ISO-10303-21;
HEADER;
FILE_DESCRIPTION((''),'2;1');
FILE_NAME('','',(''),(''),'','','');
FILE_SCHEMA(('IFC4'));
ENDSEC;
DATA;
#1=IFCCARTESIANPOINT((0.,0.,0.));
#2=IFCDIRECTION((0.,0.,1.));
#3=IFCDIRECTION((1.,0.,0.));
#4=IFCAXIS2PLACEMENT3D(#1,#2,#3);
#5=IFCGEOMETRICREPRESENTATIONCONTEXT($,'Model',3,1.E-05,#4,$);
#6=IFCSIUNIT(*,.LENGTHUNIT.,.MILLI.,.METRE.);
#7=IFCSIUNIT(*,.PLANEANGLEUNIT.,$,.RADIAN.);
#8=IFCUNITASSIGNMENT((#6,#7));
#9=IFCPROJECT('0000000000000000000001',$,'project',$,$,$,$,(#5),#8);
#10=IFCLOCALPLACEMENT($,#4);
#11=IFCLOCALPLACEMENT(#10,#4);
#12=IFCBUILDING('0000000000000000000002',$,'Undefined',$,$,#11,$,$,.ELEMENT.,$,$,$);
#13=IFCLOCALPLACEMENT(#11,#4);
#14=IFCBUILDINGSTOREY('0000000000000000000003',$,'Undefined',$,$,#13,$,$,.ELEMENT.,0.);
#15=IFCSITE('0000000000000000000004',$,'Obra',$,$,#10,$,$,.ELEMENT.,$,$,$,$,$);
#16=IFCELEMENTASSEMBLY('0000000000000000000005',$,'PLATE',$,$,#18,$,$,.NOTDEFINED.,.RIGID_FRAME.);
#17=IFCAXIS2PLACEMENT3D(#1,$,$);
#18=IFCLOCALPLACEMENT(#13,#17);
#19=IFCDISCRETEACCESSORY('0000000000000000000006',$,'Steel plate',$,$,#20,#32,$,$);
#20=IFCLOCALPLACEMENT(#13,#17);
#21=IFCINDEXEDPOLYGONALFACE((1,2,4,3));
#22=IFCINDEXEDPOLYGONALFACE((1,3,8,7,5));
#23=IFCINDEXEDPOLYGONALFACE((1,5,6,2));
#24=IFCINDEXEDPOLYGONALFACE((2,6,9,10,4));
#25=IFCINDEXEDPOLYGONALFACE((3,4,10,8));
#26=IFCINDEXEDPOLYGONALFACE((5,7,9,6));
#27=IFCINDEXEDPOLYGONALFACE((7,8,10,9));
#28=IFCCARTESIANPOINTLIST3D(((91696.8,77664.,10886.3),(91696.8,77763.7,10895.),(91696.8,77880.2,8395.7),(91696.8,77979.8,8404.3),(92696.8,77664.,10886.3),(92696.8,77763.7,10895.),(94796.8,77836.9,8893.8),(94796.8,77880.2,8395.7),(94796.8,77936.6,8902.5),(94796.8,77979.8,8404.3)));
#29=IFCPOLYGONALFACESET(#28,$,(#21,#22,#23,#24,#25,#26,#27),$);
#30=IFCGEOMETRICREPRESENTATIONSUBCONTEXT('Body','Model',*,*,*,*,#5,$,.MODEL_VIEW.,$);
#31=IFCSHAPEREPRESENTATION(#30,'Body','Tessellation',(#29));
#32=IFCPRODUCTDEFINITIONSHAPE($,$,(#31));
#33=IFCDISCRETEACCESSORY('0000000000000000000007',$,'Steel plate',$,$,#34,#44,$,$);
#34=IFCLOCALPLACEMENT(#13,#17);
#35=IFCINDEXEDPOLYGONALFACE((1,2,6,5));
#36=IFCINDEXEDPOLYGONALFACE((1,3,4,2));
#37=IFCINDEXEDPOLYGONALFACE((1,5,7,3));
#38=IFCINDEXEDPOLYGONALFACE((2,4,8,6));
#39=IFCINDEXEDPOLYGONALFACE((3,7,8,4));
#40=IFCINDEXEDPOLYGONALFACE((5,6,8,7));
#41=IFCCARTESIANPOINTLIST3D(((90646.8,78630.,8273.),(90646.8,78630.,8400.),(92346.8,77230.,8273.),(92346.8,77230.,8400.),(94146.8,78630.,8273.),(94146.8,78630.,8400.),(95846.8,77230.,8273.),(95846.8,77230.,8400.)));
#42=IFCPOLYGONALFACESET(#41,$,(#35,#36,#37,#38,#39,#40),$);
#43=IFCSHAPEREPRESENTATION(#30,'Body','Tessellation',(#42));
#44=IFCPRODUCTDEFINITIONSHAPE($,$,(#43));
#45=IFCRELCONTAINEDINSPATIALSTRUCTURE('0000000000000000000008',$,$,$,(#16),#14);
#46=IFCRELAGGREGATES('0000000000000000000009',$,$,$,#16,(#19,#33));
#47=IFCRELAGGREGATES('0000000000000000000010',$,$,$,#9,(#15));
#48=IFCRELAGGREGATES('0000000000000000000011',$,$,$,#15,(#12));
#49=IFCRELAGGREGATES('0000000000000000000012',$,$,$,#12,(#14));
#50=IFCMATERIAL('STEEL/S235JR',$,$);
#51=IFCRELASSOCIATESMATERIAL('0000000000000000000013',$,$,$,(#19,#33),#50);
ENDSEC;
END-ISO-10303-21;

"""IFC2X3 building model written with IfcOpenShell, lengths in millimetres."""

from ifc_helpers import new_model, si_unit, frame, origin_with_axes, place, context, subcontext, project, spatial, polyline, outline, extrude, material, element, aggregate, save


model = new_model("IFC2X3")

# Units and contexts
model_context = context("Model", 3, precision=1e-05, world=origin_with_axes())
body_context = subcontext(model_context, "Body", "Model", "MODEL_VIEW")
ifc_project = project(units=[si_unit("LENGTHUNIT", "METRE", prefix="MILLI"), si_unit("PLANEANGLEUNIT", "RADIAN")], contexts=[model_context])

# Site, building, storey
site_placement = place(None, origin_with_axes())
site = spatial("IfcSite", under=ifc_project, at=site_placement, Name="Obra", CompositionType="ELEMENT")
building_placement = place(site_placement, origin_with_axes())
building = spatial("IfcBuilding", under=site, at=building_placement, Name="Undefined", CompositionType="ELEMENT")
storey_placement = place(building_placement, origin_with_axes())
storey = spatial("IfcBuildingStorey", under=building, at=storey_placement, Name="Undefined", CompositionType="ELEMENT", Elevation=0.0)

# Shared definitions
ifc_material_1 = material(Name="STEEL/S235JR")

# Element assembly
assembly_1_placement = place(storey_placement, origin_with_axes())
assembly_1 = element("IfcElementAssembly", 1, at=assembly_1_placement, inside=storey, Name="PLATE", AssemblyPlace="NOTDEFINED", PredefinedType="RIGID_FRAME")

# Discrete accessories
discrete_accessory_1_placement = place(assembly_1_placement, frame((94796.8, 77886.8, 8898.1), z_axis=(0.0, 0.996255, 0.08646), x_axis=(0.0, 0.08646, -0.996255)))
discrete_accessory_1 = element("IfcDiscreteAccessory", 2, at=discrete_accessory_1_placement, material=ifc_material_1, Name="Steel plate", context=body_context, shape_type="SweptSolid", body=[
    extrude(outline(polyline([(0.0, 0.0), (500.0, 0.0), (500.0, 3100.0), (-2000.0, 3100.0), (-2000.0, 2100.0), (0.0, 0.0)])), frame((0.0, 0.0, -50.0), z_axis=(0.0, 0.0, 1.0), x_axis=(1.0, 0.0, 0.0)), (0.0, 0.0, 1.0), 100.0),
])
discrete_accessory_2_placement = place(assembly_1_placement, frame((92346.8, 77230.0, 8336.5), z_axis=(0.0, 0.0, 1.0), x_axis=(1.0, 0.0, 0.0)))
discrete_accessory_2 = element("IfcDiscreteAccessory", 3, at=discrete_accessory_2_placement, material=ifc_material_1, Name="Steel plate", context=body_context, shape_type="SweptSolid", body=[
    extrude(outline(polyline([(0.0, 0.0), (3500.0, 0.0), (1800.0, 1400.0), (-1700.0, 1400.0), (0.0, 0.0)])), frame((0.0, 0.0, -63.5), z_axis=(0.0, 0.0, 1.0), x_axis=(1.0, 0.0, 0.0)), (0.0, 0.0, 1.0), 127.0),
])
aggregate(assembly_1, [discrete_accessory_1, discrete_accessory_2])

save(model, "model.ifc")
